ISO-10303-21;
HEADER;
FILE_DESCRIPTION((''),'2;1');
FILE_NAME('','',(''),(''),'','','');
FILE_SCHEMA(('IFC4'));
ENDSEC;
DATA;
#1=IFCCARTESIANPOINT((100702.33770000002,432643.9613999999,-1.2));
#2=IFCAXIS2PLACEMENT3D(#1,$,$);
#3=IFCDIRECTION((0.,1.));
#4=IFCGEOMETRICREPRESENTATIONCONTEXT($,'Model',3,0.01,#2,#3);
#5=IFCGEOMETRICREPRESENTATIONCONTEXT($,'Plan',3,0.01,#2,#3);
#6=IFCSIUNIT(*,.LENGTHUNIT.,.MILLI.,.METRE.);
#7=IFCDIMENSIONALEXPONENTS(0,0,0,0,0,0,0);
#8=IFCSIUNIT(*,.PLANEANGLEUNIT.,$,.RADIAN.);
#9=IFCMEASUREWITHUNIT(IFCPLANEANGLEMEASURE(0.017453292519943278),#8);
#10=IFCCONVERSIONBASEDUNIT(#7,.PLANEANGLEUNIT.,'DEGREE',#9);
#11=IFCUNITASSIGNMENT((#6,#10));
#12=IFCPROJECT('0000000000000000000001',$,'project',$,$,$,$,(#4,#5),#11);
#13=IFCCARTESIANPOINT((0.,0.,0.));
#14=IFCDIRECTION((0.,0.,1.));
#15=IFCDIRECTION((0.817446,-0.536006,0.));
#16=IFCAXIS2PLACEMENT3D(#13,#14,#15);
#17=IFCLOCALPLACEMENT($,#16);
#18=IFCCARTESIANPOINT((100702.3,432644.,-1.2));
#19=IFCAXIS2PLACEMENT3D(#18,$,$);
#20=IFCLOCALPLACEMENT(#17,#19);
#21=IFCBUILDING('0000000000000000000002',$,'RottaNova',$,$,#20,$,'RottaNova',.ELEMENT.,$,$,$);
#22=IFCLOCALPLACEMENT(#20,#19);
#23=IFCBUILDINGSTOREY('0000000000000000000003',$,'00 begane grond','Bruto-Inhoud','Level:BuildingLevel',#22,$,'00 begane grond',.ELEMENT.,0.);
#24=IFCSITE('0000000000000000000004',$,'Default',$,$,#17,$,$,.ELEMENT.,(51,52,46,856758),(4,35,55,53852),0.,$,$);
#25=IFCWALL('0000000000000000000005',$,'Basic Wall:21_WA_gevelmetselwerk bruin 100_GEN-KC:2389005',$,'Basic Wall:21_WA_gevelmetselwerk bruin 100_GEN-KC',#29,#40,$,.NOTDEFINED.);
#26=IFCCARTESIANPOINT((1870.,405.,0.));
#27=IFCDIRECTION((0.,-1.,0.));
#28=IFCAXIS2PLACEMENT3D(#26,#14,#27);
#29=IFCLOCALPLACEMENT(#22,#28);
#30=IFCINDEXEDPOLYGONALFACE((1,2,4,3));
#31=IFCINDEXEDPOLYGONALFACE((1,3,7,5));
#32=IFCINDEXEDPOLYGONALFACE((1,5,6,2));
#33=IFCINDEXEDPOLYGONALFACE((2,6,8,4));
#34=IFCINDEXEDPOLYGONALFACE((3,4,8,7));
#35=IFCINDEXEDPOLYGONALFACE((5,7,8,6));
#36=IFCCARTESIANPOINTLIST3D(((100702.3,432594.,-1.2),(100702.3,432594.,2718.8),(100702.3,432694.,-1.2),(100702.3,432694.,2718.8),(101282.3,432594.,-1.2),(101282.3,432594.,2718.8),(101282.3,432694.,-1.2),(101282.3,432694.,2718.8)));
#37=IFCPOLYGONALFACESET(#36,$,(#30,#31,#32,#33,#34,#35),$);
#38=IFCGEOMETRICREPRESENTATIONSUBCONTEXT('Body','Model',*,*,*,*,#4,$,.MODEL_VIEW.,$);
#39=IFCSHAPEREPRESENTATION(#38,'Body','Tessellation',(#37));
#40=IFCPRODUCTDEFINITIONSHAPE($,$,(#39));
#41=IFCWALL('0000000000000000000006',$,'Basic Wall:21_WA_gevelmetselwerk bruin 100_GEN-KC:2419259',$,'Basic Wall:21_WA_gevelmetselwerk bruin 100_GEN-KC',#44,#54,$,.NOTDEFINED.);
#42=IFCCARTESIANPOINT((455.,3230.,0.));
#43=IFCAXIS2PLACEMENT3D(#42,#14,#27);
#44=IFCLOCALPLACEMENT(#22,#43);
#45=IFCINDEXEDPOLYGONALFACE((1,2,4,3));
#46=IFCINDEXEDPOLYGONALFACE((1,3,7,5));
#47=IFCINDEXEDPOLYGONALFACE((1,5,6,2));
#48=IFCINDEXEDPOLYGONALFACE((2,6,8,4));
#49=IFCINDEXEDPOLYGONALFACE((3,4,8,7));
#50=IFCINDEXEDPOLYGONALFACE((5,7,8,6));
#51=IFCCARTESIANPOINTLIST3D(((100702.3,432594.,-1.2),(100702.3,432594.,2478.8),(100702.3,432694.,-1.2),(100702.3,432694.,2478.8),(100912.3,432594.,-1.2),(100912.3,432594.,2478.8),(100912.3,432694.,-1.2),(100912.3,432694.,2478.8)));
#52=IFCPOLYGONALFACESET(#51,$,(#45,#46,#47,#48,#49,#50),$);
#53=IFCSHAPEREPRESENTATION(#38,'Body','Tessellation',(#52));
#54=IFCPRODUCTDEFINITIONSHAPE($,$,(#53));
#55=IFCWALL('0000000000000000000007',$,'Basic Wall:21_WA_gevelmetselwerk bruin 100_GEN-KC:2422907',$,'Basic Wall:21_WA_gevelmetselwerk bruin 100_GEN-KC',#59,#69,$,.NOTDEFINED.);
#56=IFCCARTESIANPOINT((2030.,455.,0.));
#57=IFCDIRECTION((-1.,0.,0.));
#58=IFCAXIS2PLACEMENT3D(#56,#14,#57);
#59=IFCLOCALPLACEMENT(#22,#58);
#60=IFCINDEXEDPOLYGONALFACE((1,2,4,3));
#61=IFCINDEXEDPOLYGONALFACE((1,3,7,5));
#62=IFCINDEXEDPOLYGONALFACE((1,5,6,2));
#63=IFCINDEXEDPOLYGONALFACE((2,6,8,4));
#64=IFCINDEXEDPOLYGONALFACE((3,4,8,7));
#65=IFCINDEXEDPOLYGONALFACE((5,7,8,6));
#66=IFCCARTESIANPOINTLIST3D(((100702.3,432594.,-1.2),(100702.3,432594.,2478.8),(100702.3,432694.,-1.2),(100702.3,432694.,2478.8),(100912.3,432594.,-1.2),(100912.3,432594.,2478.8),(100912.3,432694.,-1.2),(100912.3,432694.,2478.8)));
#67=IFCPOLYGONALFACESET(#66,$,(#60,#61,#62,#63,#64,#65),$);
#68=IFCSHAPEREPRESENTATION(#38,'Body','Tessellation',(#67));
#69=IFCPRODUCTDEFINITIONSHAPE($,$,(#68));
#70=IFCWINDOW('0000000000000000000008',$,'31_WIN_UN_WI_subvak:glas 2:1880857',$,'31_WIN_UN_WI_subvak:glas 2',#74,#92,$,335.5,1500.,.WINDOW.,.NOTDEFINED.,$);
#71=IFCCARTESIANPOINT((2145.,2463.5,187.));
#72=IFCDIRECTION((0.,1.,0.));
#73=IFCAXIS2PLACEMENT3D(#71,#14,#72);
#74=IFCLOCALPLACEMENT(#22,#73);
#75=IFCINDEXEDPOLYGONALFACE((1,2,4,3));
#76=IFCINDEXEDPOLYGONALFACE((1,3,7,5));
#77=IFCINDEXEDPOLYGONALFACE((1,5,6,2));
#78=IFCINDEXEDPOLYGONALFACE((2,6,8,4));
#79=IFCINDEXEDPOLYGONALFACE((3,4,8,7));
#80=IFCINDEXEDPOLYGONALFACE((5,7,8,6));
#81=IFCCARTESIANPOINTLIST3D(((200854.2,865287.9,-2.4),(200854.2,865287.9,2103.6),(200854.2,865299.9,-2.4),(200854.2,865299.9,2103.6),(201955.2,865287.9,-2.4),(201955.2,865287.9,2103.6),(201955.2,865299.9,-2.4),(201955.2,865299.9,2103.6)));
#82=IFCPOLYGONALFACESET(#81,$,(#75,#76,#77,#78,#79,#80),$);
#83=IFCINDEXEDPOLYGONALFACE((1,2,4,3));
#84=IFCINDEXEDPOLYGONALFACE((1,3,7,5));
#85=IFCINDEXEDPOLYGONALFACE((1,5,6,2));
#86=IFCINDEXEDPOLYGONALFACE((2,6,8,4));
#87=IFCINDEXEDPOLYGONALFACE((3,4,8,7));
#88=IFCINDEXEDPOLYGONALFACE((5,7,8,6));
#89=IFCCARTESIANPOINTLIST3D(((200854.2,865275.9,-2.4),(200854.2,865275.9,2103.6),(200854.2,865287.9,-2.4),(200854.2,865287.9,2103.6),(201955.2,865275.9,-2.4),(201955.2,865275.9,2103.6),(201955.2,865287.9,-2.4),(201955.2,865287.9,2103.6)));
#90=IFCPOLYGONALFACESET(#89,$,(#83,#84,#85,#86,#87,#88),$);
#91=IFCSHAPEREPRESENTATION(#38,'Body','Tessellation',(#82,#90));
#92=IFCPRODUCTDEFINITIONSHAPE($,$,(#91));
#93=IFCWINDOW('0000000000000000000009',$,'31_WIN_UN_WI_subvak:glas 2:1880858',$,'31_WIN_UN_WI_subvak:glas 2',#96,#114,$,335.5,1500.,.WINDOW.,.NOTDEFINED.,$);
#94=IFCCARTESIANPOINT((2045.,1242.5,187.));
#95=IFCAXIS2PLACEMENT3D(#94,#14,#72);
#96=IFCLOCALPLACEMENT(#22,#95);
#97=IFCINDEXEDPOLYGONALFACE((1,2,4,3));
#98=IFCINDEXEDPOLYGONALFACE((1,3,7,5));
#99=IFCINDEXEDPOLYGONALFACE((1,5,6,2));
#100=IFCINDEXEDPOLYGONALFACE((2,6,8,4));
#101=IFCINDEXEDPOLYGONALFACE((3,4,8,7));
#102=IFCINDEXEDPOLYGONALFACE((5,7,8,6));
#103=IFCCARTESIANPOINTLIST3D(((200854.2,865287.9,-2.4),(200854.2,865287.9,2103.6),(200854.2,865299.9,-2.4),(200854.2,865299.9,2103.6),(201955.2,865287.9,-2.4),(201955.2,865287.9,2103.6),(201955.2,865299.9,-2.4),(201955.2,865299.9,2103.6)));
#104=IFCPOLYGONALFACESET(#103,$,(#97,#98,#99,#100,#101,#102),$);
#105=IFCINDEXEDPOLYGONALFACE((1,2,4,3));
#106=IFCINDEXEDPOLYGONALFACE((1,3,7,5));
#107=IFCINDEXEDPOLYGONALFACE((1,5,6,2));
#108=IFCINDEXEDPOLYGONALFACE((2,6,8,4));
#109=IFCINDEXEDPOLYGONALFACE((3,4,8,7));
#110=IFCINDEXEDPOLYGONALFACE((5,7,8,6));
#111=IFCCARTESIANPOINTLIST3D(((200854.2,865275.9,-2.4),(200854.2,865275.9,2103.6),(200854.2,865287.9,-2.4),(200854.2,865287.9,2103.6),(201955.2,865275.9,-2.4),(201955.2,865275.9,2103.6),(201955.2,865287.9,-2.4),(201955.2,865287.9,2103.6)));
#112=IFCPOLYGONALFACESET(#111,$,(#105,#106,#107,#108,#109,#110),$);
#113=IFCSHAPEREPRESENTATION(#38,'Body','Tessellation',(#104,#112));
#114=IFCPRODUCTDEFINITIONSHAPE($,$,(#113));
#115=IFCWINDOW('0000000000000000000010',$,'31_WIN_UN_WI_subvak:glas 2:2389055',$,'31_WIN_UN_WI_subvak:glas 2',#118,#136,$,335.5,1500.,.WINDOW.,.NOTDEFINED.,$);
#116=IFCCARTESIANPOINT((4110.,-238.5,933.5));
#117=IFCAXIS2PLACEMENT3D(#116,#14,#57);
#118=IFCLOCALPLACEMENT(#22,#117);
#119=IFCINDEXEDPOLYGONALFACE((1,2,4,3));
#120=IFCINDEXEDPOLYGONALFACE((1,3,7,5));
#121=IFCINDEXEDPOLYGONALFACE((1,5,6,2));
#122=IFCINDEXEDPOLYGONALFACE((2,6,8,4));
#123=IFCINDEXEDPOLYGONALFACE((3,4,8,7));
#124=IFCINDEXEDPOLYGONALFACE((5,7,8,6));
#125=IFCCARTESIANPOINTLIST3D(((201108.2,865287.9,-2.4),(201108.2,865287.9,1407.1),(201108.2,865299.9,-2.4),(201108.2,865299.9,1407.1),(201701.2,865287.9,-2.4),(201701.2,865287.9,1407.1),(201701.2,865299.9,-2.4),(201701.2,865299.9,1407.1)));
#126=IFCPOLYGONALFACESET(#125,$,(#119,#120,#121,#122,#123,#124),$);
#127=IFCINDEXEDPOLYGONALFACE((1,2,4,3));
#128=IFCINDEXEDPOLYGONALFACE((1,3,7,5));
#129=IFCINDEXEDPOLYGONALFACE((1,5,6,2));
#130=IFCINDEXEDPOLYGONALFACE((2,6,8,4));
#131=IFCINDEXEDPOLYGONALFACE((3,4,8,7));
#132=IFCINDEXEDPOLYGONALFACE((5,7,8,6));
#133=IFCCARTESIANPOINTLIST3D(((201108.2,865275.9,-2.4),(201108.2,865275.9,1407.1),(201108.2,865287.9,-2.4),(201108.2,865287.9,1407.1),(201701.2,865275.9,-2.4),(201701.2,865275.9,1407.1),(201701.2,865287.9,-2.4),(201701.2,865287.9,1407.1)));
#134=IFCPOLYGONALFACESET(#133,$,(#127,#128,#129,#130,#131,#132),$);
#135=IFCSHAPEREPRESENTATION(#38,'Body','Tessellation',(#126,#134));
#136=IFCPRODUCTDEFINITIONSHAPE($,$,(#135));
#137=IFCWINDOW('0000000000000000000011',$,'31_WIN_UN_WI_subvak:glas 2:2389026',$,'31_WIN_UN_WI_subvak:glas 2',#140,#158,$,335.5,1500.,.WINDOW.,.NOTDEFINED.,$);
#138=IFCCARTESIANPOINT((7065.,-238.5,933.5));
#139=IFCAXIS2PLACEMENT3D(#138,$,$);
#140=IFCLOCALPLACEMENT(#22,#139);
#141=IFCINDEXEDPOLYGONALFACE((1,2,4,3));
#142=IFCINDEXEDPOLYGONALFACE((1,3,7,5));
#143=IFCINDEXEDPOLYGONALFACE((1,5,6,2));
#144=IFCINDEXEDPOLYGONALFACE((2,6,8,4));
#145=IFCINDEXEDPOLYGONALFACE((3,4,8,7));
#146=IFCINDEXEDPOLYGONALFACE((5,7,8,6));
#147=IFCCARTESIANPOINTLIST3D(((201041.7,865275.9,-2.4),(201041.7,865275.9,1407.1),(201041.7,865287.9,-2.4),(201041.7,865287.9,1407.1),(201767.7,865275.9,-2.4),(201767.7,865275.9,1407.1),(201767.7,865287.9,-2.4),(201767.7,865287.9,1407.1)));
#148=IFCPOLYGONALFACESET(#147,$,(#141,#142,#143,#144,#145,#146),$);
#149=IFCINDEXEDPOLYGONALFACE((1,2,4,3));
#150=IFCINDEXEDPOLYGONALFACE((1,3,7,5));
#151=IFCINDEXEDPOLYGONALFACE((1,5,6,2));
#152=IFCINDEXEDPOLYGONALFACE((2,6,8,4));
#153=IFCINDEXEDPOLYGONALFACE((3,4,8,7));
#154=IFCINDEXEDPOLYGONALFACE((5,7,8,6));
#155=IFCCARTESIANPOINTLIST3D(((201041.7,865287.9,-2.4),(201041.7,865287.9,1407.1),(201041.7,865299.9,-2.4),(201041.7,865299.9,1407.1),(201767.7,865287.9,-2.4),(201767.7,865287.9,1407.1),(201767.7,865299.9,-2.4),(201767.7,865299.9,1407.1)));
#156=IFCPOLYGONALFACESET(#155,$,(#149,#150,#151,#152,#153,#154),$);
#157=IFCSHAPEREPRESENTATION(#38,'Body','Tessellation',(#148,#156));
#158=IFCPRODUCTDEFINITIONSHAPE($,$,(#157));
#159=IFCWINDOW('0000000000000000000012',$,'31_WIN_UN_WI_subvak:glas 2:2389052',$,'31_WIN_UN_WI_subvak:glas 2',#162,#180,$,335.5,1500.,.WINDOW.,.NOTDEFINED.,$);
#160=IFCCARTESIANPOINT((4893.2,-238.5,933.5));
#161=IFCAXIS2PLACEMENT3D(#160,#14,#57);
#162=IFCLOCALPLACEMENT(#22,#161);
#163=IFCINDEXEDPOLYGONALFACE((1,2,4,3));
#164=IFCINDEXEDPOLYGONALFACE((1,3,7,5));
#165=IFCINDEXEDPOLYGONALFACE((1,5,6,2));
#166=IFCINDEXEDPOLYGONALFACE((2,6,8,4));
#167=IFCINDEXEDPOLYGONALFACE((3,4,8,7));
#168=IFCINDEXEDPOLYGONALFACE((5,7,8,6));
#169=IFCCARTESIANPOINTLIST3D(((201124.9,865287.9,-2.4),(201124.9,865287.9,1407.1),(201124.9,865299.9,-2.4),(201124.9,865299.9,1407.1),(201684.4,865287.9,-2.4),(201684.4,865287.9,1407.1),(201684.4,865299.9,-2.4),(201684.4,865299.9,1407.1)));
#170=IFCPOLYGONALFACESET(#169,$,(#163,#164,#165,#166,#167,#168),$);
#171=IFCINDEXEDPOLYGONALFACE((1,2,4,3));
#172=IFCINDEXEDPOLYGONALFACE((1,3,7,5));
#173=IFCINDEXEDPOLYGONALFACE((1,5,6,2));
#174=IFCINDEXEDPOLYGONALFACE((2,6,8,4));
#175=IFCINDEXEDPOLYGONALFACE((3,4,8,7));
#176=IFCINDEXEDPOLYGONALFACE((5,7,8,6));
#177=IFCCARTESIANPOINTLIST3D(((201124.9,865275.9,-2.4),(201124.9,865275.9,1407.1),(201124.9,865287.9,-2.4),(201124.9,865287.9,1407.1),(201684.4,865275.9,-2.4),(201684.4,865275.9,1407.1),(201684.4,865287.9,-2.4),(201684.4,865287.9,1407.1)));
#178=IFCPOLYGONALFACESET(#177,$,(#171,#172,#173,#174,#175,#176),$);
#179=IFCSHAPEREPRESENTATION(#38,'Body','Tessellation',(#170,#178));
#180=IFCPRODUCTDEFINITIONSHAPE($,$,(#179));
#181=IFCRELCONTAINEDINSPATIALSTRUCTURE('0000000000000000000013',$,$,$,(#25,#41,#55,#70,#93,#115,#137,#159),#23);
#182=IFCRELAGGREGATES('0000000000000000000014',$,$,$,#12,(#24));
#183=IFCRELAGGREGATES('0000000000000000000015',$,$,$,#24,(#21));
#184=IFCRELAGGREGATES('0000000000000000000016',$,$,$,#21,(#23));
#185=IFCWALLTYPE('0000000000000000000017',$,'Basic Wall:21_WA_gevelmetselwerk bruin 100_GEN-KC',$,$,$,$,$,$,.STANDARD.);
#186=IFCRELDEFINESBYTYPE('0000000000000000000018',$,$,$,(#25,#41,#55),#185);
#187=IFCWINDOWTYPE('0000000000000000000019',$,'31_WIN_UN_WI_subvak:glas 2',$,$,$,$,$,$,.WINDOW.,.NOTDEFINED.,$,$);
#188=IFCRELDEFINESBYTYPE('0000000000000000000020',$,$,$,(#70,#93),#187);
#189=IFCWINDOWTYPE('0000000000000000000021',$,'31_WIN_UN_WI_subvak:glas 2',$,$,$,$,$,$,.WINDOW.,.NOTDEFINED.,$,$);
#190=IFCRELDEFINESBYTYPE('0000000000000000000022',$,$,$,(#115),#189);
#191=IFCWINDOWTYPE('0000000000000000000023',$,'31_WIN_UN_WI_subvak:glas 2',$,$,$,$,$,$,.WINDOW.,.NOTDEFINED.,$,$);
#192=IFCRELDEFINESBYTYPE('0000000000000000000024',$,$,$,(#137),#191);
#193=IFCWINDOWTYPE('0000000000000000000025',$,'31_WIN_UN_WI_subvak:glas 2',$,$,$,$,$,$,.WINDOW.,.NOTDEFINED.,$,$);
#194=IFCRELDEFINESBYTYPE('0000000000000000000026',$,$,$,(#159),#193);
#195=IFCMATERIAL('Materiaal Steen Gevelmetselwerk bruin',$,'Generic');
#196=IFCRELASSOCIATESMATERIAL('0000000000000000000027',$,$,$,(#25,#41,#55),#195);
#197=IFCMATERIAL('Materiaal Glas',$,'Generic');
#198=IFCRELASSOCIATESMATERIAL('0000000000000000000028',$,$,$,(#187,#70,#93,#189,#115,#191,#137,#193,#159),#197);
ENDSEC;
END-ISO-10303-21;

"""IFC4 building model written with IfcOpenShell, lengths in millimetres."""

from ifc_helpers import new_model, entity, si_unit, converted_unit, direction, frame, place, context, subcontext, project, spatial, indexed_curve, outline, extrude, source, transform, mapped, material, type_object, type_shapes, element, save


model = new_model("IFC4")

# Units and contexts
model_context = context("Model", 3, precision=0.01, world=frame((100702.33770000002, 432643.9613999999, -1.2)), true_north=direction((0.0, 1.0)))
plan_context = context("Plan", 3, precision=0.01, world=frame((100702.33770000002, 432643.9613999999, -1.2)), true_north=direction((0.0, 1.0)))
body_context = subcontext(model_context, "Body", "Model", "MODEL_VIEW")
ifc_project = project(units=[si_unit("LENGTHUNIT", "METRE", prefix="MILLI"), converted_unit("PLANEANGLEUNIT", "DEGREE", entity("IfcPlaneAngleMeasure", 0.017453292519943278), si_unit("PLANEANGLEUNIT", "RADIAN"), dimensions=[0, 0, 0, 0, 0, 0, 0])], contexts=[model_context, plan_context])

# Site, building, storey
site_placement = place(None, frame((0.0, 0.0, 0.0), z_axis=(0.0, 0.0, 1.0), x_axis=(0.817446, -0.536006, 0.0)))
site = spatial("IfcSite", under=ifc_project, at=site_placement, Name="Default", CompositionType="ELEMENT", RefLatitude=(51, 52, 46, 856758), RefLongitude=(4, 35, 55, 53852), RefElevation=0.0)
building_placement = place(site_placement, frame((100702.3, 432644.0, -1.2)))
building = spatial("IfcBuilding", under=site, at=building_placement, Name="RottaNova", LongName="RottaNova", CompositionType="ELEMENT")
storey_placement = place(building_placement, frame((100702.3, 432644.0, -1.2)))
storey = spatial("IfcBuildingStorey", under=building, at=storey_placement, Name="00 begane grond", Description="Bruto-Inhoud", ObjectType="Level:BuildingLevel", LongName="00 begane grond", CompositionType="ELEMENT", Elevation=0.0)

# Walls
ifc_material_1 = material(Name="Materiaal Steen Gevelmetselwerk bruin", Category="Generic")
wall_type_1 = type_object("IfcWallType", Name="Basic Wall:21_WA_gevelmetselwerk bruin 100_GEN-KC", PredefinedType="STANDARD")
wall_1_placement = place(storey_placement, frame((1870.0, 405.0, 0.0), z_axis=(0.0, 0.0, 1.0), x_axis=(0.0, -1.0, 0.0)))
element("IfcWall", 1, at=wall_1_placement, inside=storey, type_object=wall_type_1, material=ifc_material_1, Name="Basic Wall:21_WA_gevelmetselwerk bruin 100_GEN-KC:2389005", ObjectType="Basic Wall:21_WA_gevelmetselwerk bruin 100_GEN-KC", PredefinedType="NOTDEFINED", context=body_context, shape_type="SweptSolid", body=[
    extrude(outline(indexed_curve([(580.0, 50.0), (0.0, 50.0), (0.0, -50.0), (580.0, -50.0), (580.0, 50.0)], self_intersect=False)), frame((100702.3, 432644.0, -1.2)), (0.0, 0.0, 1.0), 2720.0),
])
wall_2_placement = place(storey_placement, frame((455.0, 3230.0, 0.0), z_axis=(0.0, 0.0, 1.0), x_axis=(0.0, -1.0, 0.0)))
element("IfcWall", 2, at=wall_2_placement, inside=storey, type_object=wall_type_1, material=ifc_material_1, Name="Basic Wall:21_WA_gevelmetselwerk bruin 100_GEN-KC:2419259", ObjectType="Basic Wall:21_WA_gevelmetselwerk bruin 100_GEN-KC", PredefinedType="NOTDEFINED", context=body_context, shape_type="SweptSolid", body=[
    extrude(outline(indexed_curve([(210.0, 50.0), (0.0, 50.0), (0.0, -50.0), (210.0, -50.0), (210.0, 50.0)], self_intersect=False)), frame((100702.3, 432644.0, -1.2)), (0.0, 0.0, 1.0), 2480.0),
])
wall_3_placement = place(storey_placement, frame((2030.0, 455.0, 0.0), z_axis=(0.0, 0.0, 1.0), x_axis=(-1.0, 0.0, 0.0)))
element("IfcWall", 3, at=wall_3_placement, inside=storey, type_object=wall_type_1, material=ifc_material_1, Name="Basic Wall:21_WA_gevelmetselwerk bruin 100_GEN-KC:2422907", ObjectType="Basic Wall:21_WA_gevelmetselwerk bruin 100_GEN-KC", PredefinedType="NOTDEFINED", context=body_context, shape_type="SweptSolid", body=[
    extrude(outline(indexed_curve([(210.0, 50.0), (0.0, 50.0), (0.0, -50.0), (210.0, -50.0), (210.0, 50.0)], self_intersect=False)), frame((100702.3, 432644.0, -1.2)), (0.0, 0.0, 1.0), 2480.0),
])

# Windows
ifc_material_2 = material(Name="Materiaal Glas", Category="Generic")
window_type_1 = type_object("IfcWindowType", Name="31_WIN_UN_WI_subvak:glas 2", PartitioningType="NOTDEFINED", PredefinedType="WINDOW", material=ifc_material_2)
shared_shape_1 = source(frame((100702.3, 432644.0, -1.2)), body_context, "Body", "SweptSolid", [
    extrude(outline(indexed_curve([(-6.0, -550.5), (6.0, -550.5), (6.0, 550.5), (-6.0, 550.5), (-6.0, -550.5)], self_intersect=False)), frame((0.0, 6.0, 0.0), z_axis=(0.0, 0.0, 1.0), x_axis=(0.0, -1.0, 0.0)), (0.0, 0.0, 1.0), 2106.0),
    extrude(outline(indexed_curve([(-6.0, -550.5), (6.0, -550.5), (6.0, 550.5), (-6.0, 550.5), (-6.0, -550.5)], self_intersect=False)), frame((0.0, -6.0, 0.0), z_axis=(0.0, 0.0, 1.0), x_axis=(0.0, -1.0, 0.0)), (0.0, 0.0, 1.0), 2106.0),
])
type_shapes(window_type_1, [shared_shape_1])
for number, where, z_axis, x_axis, name in (
    (4, (2145.0, 2463.5, 187.0), (0.0, 0.0, 1.0), (0.0, 1.0, 0.0), "31_WIN_UN_WI_subvak:glas 2:1880857"),
    (5, (2045.0, 1242.5, 187.0), (0.0, 0.0, 1.0), (0.0, 1.0, 0.0), "31_WIN_UN_WI_subvak:glas 2:1880858"),
):
    element("IfcWindow", number, at=place(storey_placement, frame(where, z_axis=z_axis, x_axis=x_axis)), inside=storey, type_object=window_type_1, material=ifc_material_2, Name=name, ObjectType="31_WIN_UN_WI_subvak:glas 2", OverallHeight=335.5, OverallWidth=1500.0, PartitioningType="NOTDEFINED", PredefinedType="WINDOW", context=body_context, shape_type="MappedRepresentation", body=[
        mapped(shared_shape_1, transform((100702.3, 432644.0, -1.2), scale=1.0)),
    ])
window_type_2 = type_object("IfcWindowType", Name="31_WIN_UN_WI_subvak:glas 2", PartitioningType="NOTDEFINED", PredefinedType="WINDOW", material=ifc_material_2)
shared_shape_2 = source(frame((100702.3, 432644.0, -1.2)), body_context, "Body", "SweptSolid", [
    extrude(outline(indexed_curve([(-6.0, -296.5), (6.0, -296.5), (6.0, 296.5), (-6.0, 296.5), (-6.0, -296.5)], self_intersect=False)), frame((0.0, 6.0, 0.0), z_axis=(0.0, 0.0, 1.0), x_axis=(0.0, -1.0, 0.0)), (0.0, 0.0, 1.0), 1409.5),
    extrude(outline(indexed_curve([(-6.0, -296.5), (6.0, -296.5), (6.0, 296.5), (-6.0, 296.5), (-6.0, -296.5)], self_intersect=False)), frame((0.0, -6.0, 0.0), z_axis=(0.0, 0.0, 1.0), x_axis=(0.0, -1.0, 0.0)), (0.0, 0.0, 1.0), 1409.5),
])
type_shapes(window_type_2, [shared_shape_2])
window_1_placement = place(storey_placement, frame((4110.0, -238.5, 933.5), z_axis=(0.0, 0.0, 1.0), x_axis=(-1.0, 0.0, 0.0)))
element("IfcWindow", 6, at=window_1_placement, inside=storey, type_object=window_type_2, material=ifc_material_2, Name="31_WIN_UN_WI_subvak:glas 2:2389055", ObjectType="31_WIN_UN_WI_subvak:glas 2", OverallHeight=335.5, OverallWidth=1500.0, PartitioningType="NOTDEFINED", PredefinedType="WINDOW", context=body_context, shape_type="MappedRepresentation", body=[
    mapped(shared_shape_2, transform((100702.3, 432644.0, -1.2), scale=1.0)),
])
window_type_3 = type_object("IfcWindowType", Name="31_WIN_UN_WI_subvak:glas 2", PartitioningType="NOTDEFINED", PredefinedType="WINDOW", material=ifc_material_2)
shared_shape_3 = source(frame((100702.3, 432644.0, -1.2)), body_context, "Body", "SweptSolid", [
    extrude(outline(indexed_curve([(-363.0, -6.0), (363.0, -6.0), (363.0, 6.0), (-363.0, 6.0), (-363.0, -6.0)], self_intersect=False)), frame((0.0, -6.0, 0.0)), (0.0, 0.0, 1.0), 1409.5),
    extrude(outline(indexed_curve([(-363.0, -6.0), (363.0, -6.0), (363.0, 6.0), (-363.0, 6.0), (-363.0, -6.0)], self_intersect=False)), frame((0.0, 6.0, 0.0)), (0.0, 0.0, 1.0), 1409.5),
])
type_shapes(window_type_3, [shared_shape_3])
window_2_placement = place(storey_placement, frame((7065.0, -238.5, 933.5)))
element("IfcWindow", 7, at=window_2_placement, inside=storey, type_object=window_type_3, material=ifc_material_2, Name="31_WIN_UN_WI_subvak:glas 2:2389026", ObjectType="31_WIN_UN_WI_subvak:glas 2", OverallHeight=335.5, OverallWidth=1500.0, PartitioningType="NOTDEFINED", PredefinedType="WINDOW", context=body_context, shape_type="MappedRepresentation", body=[
    mapped(shared_shape_3, transform((100702.3, 432644.0, -1.2), scale=1.0)),
])
window_type_4 = type_object("IfcWindowType", Name="31_WIN_UN_WI_subvak:glas 2", PartitioningType="NOTDEFINED", PredefinedType="WINDOW", material=ifc_material_2)
shared_shape_4 = source(frame((100702.3, 432644.0, -1.2)), body_context, "Body", "SweptSolid", [
    extrude(outline(indexed_curve([(-6.0, -279.8), (6.0, -279.8), (6.0, 279.8), (-6.0, 279.8), (-6.0, -279.8)], self_intersect=False)), frame((0.0, 6.0, 0.0), z_axis=(0.0, 0.0, 1.0), x_axis=(0.0, -1.0, 0.0)), (0.0, 0.0, 1.0), 1409.5),
    extrude(outline(indexed_curve([(-6.0, -279.8), (6.0, -279.8), (6.0, 279.8), (-6.0, 279.8), (-6.0, -279.8)], self_intersect=False)), frame((0.0, -6.0, 0.0), z_axis=(0.0, 0.0, 1.0), x_axis=(0.0, -1.0, 0.0)), (0.0, 0.0, 1.0), 1409.5),
])
type_shapes(window_type_4, [shared_shape_4])
for number, where, z_axis, x_axis, name in (
    (8, (4893.2, -238.5, 933.5), (0.0, 0.0, 1.0), (-1.0, 0.0, 0.0), "31_WIN_UN_WI_subvak:glas 2:2389052"),
):
    element("IfcWindow", number, at=place(storey_placement, frame(where, z_axis=z_axis, x_axis=x_axis)), inside=storey, type_object=window_type_4, material=ifc_material_2, Name=name, ObjectType="31_WIN_UN_WI_subvak:glas 2", OverallHeight=335.5, OverallWidth=1500.0, PartitioningType="NOTDEFINED", PredefinedType="WINDOW", context=body_context, shape_type="MappedRepresentation", body=[
        mapped(shared_shape_4, transform((100702.3, 432644.0, -1.2), scale=1.0)),
    ])

save(model, "model.ifc")
